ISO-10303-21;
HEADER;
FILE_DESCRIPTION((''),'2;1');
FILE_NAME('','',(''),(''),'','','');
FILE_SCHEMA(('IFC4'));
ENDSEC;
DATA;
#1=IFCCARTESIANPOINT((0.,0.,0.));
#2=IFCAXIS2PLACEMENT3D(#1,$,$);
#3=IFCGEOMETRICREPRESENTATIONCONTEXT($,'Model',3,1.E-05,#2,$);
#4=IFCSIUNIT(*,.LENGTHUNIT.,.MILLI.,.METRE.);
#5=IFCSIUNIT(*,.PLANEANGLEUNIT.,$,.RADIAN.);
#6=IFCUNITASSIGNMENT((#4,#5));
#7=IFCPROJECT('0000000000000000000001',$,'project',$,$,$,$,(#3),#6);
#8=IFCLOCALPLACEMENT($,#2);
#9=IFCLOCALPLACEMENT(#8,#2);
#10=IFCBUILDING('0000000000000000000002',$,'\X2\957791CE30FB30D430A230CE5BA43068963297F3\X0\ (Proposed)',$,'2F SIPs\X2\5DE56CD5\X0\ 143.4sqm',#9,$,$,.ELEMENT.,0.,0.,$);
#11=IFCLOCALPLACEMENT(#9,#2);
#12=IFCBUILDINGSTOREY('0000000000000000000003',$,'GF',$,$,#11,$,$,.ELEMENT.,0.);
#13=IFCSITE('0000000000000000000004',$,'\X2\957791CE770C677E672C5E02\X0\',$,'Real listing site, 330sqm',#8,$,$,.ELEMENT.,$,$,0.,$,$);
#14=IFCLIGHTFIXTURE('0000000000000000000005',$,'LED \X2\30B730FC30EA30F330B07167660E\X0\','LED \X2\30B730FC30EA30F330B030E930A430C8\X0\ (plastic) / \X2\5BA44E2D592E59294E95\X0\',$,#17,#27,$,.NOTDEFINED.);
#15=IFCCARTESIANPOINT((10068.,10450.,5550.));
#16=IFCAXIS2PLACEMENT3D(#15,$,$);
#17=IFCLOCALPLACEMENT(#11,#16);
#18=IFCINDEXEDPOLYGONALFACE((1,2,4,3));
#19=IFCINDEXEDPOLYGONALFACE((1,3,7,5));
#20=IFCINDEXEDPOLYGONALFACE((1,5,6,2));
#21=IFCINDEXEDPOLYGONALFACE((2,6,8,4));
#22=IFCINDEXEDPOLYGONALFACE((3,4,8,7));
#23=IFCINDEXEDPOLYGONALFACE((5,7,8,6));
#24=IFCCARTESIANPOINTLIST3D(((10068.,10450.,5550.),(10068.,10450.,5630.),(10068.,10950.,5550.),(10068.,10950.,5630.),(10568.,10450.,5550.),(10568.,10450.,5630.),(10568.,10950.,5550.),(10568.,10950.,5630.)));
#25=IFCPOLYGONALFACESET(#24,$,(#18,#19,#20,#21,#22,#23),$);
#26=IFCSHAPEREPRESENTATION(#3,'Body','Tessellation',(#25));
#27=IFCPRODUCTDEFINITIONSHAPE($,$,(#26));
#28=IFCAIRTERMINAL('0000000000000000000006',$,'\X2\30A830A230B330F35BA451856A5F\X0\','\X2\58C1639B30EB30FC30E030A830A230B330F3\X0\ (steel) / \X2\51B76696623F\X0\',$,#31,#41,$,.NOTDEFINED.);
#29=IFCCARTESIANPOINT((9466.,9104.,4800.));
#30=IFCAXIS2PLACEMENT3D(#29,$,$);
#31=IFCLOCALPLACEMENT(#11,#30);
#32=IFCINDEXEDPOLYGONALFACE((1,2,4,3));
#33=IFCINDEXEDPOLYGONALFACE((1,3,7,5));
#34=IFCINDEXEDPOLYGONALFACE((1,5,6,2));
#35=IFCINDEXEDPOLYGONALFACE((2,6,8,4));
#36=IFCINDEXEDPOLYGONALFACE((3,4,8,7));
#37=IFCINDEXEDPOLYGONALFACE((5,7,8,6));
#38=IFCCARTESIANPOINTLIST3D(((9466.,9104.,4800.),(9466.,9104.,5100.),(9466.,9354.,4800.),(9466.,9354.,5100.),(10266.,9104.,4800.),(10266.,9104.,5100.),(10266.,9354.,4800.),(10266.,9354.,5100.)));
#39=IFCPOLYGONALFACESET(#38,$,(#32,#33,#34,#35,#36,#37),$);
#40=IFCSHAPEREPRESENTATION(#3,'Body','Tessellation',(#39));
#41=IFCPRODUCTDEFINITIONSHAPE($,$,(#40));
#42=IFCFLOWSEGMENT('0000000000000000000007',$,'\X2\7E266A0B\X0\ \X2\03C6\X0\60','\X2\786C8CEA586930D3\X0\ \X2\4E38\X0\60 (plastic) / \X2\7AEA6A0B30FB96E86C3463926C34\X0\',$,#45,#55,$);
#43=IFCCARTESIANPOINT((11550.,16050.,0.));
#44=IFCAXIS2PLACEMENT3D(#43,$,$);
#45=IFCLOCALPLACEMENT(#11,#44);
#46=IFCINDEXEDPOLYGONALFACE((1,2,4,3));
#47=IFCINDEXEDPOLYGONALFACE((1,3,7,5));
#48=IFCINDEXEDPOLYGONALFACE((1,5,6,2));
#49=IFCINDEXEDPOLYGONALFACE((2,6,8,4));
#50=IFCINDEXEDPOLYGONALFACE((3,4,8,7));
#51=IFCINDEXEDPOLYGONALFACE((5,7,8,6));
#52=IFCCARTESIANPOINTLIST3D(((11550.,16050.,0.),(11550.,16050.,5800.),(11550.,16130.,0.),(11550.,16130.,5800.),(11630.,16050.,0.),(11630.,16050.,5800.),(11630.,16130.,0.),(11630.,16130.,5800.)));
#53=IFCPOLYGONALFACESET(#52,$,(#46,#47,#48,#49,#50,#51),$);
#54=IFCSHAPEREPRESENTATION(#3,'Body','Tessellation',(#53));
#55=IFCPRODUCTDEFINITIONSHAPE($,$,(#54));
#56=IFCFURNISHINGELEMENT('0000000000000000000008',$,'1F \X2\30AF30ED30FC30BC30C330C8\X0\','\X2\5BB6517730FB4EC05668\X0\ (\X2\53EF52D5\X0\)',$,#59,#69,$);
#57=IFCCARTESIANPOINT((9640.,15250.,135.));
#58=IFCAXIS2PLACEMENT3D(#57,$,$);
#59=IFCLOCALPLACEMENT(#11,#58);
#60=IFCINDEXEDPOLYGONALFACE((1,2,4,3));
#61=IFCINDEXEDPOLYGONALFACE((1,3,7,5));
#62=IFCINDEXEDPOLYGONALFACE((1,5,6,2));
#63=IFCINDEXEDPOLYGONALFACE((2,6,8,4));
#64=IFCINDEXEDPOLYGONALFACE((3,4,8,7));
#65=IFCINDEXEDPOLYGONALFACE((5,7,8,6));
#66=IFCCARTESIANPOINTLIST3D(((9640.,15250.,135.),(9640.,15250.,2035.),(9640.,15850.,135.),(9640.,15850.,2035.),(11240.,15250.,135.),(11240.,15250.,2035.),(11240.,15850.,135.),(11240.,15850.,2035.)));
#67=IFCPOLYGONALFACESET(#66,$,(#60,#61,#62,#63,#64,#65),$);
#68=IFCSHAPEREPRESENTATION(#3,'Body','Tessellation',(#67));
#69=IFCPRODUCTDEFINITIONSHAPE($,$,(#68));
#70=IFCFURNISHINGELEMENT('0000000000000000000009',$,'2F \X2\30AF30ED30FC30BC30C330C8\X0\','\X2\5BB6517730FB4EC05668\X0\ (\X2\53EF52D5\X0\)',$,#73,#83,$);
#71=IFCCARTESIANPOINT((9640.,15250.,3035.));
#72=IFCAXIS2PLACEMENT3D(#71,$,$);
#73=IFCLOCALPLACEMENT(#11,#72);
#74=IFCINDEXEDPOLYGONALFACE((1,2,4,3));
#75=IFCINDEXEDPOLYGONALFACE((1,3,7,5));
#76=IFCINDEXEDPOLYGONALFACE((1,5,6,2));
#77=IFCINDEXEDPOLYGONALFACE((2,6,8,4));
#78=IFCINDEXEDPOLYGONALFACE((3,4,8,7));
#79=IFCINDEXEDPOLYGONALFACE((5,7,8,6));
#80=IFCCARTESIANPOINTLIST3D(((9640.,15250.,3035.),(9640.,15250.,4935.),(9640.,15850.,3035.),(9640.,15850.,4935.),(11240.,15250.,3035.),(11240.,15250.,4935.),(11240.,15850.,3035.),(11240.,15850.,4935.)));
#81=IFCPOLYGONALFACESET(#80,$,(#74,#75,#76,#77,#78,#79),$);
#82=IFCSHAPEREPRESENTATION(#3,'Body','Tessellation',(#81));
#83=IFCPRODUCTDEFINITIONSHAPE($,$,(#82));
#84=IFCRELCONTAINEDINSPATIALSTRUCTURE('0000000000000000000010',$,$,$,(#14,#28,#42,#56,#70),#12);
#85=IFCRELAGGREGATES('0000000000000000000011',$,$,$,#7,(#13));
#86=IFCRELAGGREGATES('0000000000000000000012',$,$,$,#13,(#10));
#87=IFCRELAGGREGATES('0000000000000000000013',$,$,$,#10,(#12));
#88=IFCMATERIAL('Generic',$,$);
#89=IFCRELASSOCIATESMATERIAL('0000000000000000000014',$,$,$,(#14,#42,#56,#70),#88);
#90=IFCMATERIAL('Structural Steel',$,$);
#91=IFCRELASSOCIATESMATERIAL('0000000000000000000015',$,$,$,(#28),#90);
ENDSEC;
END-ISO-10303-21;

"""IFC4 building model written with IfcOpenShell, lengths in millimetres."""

from ifc_helpers import new_model, si_unit, frame, frame_2d, origin, place, context, project, spatial, rectangle, extrude, material, element, save


model = new_model("IFC4")

# Units and contexts
model_context = context("Model", 3, precision=1e-05, world=origin())
ifc_project = project(units=[si_unit("LENGTHUNIT", "METRE", prefix="MILLI"), si_unit("PLANEANGLEUNIT", "RADIAN")], contexts=[model_context])

# Site, building, storey
site_placement = place(None, origin())
site = spatial("IfcSite", under=ifc_project, at=site_placement, Name="長野県松本市", ObjectType="Real listing site, 330sqm", CompositionType="ELEMENT", RefElevation=0.0)
building_placement = place(site_placement, origin())
building = spatial("IfcBuilding", under=site, at=building_placement, Name="長野・ピアノ室と防音 (Proposed)", ObjectType="2F SIPs工法 143.4sqm", CompositionType="ELEMENT", ElevationOfRefHeight=0.0, ElevationOfTerrain=0.0)
storey_placement = place(building_placement, origin())
storey = spatial("IfcBuildingStorey", under=building, at=storey_placement, Name="GF", CompositionType="ELEMENT", Elevation=0.0)

# Shared definitions
ifc_material_1 = material(Name="Structural Steel")

# Light fixture
ifc_material_2 = material(Name="Generic")
light_fixture_1_placement = place(storey_placement, frame((10068.0, 10450.0, 5550.0)))
element("IfcLightFixture", 1, at=light_fixture_1_placement, inside=storey, material=ifc_material_2, Name="LED シーリング照明", Description="LED シーリングライト (plastic) / 室中央天井", PredefinedType="NOTDEFINED", context=model_context, shape_type="SweptSolid", body=[
    extrude(rectangle(XDim=500.0, YDim=500.0, at=frame_2d((250.0, 250.0))), frame((10068.0, 10450.0, 5550.0)), (0.0, 0.0, 1.0), 80.0),
])

# Air terminal
air_terminal_placement = place(storey_placement, frame((9466.0, 9104.0, 4800.0)))
element("IfcAirTerminal", 2, at=air_terminal_placement, inside=storey, material=ifc_material_1, Name="エアコン室内機", Description="壁掛ルームエアコン (steel) / 冷暖房", PredefinedType="NOTDEFINED", context=model_context, shape_type="SweptSolid", body=[
    extrude(rectangle(XDim=800.0, YDim=250.0, at=frame_2d((400.0, 125.0))), frame((9466.0, 9104.0, 4800.0)), (0.0, 0.0, 1.0), 300.0),
])

# Flow segment
flow_segment_placement = place(storey_placement, frame((11550.0, 16050.0, 0.0)))
element("IfcFlowSegment", 3, at=flow_segment_placement, inside=storey, material=ifc_material_2, Name="縦樋 φ60", Description="硬質塩ビ 丸60 (plastic) / 竪樋・雨水排水", context=model_context, shape_type="SweptSolid", body=[
    extrude(rectangle(XDim=80.0, YDim=80.0, at=frame_2d((40.0, 40.0))), frame((11550.0, 16050.0, 0.0)), (0.0, 0.0, 1.0), 5800.0),
])

# Furnishing elements
furnishing_1_placement = place(storey_placement, frame((9640.0, 15250.0, 135.0)))
element("IfcFurnishingElement", 4, at=furnishing_1_placement, inside=storey, material=ifc_material_2, Name="1F クローゼット", Description="家具・什器 (可動)", context=model_context, shape_type="SweptSolid", body=[
    extrude(rectangle(XDim=1600.0, YDim=600.0, at=frame_2d((800.0, 300.0))), frame((9640.0, 15250.0, 135.0)), (0.0, 0.0, 1.0), 1900.0),
])
furnishing_2_placement = place(storey_placement, frame((9640.0, 15250.0, 3035.0)))
element("IfcFurnishingElement", 5, at=furnishing_2_placement, inside=storey, material=ifc_material_2, Name="2F クローゼット", Description="家具・什器 (可動)", context=model_context, shape_type="SweptSolid", body=[
    extrude(rectangle(XDim=1600.0, YDim=600.0, at=frame_2d((800.0, 300.0))), frame((9640.0, 15250.0, 3035.0)), (0.0, 0.0, 1.0), 1900.0),
])

save(model, "model.ifc")
